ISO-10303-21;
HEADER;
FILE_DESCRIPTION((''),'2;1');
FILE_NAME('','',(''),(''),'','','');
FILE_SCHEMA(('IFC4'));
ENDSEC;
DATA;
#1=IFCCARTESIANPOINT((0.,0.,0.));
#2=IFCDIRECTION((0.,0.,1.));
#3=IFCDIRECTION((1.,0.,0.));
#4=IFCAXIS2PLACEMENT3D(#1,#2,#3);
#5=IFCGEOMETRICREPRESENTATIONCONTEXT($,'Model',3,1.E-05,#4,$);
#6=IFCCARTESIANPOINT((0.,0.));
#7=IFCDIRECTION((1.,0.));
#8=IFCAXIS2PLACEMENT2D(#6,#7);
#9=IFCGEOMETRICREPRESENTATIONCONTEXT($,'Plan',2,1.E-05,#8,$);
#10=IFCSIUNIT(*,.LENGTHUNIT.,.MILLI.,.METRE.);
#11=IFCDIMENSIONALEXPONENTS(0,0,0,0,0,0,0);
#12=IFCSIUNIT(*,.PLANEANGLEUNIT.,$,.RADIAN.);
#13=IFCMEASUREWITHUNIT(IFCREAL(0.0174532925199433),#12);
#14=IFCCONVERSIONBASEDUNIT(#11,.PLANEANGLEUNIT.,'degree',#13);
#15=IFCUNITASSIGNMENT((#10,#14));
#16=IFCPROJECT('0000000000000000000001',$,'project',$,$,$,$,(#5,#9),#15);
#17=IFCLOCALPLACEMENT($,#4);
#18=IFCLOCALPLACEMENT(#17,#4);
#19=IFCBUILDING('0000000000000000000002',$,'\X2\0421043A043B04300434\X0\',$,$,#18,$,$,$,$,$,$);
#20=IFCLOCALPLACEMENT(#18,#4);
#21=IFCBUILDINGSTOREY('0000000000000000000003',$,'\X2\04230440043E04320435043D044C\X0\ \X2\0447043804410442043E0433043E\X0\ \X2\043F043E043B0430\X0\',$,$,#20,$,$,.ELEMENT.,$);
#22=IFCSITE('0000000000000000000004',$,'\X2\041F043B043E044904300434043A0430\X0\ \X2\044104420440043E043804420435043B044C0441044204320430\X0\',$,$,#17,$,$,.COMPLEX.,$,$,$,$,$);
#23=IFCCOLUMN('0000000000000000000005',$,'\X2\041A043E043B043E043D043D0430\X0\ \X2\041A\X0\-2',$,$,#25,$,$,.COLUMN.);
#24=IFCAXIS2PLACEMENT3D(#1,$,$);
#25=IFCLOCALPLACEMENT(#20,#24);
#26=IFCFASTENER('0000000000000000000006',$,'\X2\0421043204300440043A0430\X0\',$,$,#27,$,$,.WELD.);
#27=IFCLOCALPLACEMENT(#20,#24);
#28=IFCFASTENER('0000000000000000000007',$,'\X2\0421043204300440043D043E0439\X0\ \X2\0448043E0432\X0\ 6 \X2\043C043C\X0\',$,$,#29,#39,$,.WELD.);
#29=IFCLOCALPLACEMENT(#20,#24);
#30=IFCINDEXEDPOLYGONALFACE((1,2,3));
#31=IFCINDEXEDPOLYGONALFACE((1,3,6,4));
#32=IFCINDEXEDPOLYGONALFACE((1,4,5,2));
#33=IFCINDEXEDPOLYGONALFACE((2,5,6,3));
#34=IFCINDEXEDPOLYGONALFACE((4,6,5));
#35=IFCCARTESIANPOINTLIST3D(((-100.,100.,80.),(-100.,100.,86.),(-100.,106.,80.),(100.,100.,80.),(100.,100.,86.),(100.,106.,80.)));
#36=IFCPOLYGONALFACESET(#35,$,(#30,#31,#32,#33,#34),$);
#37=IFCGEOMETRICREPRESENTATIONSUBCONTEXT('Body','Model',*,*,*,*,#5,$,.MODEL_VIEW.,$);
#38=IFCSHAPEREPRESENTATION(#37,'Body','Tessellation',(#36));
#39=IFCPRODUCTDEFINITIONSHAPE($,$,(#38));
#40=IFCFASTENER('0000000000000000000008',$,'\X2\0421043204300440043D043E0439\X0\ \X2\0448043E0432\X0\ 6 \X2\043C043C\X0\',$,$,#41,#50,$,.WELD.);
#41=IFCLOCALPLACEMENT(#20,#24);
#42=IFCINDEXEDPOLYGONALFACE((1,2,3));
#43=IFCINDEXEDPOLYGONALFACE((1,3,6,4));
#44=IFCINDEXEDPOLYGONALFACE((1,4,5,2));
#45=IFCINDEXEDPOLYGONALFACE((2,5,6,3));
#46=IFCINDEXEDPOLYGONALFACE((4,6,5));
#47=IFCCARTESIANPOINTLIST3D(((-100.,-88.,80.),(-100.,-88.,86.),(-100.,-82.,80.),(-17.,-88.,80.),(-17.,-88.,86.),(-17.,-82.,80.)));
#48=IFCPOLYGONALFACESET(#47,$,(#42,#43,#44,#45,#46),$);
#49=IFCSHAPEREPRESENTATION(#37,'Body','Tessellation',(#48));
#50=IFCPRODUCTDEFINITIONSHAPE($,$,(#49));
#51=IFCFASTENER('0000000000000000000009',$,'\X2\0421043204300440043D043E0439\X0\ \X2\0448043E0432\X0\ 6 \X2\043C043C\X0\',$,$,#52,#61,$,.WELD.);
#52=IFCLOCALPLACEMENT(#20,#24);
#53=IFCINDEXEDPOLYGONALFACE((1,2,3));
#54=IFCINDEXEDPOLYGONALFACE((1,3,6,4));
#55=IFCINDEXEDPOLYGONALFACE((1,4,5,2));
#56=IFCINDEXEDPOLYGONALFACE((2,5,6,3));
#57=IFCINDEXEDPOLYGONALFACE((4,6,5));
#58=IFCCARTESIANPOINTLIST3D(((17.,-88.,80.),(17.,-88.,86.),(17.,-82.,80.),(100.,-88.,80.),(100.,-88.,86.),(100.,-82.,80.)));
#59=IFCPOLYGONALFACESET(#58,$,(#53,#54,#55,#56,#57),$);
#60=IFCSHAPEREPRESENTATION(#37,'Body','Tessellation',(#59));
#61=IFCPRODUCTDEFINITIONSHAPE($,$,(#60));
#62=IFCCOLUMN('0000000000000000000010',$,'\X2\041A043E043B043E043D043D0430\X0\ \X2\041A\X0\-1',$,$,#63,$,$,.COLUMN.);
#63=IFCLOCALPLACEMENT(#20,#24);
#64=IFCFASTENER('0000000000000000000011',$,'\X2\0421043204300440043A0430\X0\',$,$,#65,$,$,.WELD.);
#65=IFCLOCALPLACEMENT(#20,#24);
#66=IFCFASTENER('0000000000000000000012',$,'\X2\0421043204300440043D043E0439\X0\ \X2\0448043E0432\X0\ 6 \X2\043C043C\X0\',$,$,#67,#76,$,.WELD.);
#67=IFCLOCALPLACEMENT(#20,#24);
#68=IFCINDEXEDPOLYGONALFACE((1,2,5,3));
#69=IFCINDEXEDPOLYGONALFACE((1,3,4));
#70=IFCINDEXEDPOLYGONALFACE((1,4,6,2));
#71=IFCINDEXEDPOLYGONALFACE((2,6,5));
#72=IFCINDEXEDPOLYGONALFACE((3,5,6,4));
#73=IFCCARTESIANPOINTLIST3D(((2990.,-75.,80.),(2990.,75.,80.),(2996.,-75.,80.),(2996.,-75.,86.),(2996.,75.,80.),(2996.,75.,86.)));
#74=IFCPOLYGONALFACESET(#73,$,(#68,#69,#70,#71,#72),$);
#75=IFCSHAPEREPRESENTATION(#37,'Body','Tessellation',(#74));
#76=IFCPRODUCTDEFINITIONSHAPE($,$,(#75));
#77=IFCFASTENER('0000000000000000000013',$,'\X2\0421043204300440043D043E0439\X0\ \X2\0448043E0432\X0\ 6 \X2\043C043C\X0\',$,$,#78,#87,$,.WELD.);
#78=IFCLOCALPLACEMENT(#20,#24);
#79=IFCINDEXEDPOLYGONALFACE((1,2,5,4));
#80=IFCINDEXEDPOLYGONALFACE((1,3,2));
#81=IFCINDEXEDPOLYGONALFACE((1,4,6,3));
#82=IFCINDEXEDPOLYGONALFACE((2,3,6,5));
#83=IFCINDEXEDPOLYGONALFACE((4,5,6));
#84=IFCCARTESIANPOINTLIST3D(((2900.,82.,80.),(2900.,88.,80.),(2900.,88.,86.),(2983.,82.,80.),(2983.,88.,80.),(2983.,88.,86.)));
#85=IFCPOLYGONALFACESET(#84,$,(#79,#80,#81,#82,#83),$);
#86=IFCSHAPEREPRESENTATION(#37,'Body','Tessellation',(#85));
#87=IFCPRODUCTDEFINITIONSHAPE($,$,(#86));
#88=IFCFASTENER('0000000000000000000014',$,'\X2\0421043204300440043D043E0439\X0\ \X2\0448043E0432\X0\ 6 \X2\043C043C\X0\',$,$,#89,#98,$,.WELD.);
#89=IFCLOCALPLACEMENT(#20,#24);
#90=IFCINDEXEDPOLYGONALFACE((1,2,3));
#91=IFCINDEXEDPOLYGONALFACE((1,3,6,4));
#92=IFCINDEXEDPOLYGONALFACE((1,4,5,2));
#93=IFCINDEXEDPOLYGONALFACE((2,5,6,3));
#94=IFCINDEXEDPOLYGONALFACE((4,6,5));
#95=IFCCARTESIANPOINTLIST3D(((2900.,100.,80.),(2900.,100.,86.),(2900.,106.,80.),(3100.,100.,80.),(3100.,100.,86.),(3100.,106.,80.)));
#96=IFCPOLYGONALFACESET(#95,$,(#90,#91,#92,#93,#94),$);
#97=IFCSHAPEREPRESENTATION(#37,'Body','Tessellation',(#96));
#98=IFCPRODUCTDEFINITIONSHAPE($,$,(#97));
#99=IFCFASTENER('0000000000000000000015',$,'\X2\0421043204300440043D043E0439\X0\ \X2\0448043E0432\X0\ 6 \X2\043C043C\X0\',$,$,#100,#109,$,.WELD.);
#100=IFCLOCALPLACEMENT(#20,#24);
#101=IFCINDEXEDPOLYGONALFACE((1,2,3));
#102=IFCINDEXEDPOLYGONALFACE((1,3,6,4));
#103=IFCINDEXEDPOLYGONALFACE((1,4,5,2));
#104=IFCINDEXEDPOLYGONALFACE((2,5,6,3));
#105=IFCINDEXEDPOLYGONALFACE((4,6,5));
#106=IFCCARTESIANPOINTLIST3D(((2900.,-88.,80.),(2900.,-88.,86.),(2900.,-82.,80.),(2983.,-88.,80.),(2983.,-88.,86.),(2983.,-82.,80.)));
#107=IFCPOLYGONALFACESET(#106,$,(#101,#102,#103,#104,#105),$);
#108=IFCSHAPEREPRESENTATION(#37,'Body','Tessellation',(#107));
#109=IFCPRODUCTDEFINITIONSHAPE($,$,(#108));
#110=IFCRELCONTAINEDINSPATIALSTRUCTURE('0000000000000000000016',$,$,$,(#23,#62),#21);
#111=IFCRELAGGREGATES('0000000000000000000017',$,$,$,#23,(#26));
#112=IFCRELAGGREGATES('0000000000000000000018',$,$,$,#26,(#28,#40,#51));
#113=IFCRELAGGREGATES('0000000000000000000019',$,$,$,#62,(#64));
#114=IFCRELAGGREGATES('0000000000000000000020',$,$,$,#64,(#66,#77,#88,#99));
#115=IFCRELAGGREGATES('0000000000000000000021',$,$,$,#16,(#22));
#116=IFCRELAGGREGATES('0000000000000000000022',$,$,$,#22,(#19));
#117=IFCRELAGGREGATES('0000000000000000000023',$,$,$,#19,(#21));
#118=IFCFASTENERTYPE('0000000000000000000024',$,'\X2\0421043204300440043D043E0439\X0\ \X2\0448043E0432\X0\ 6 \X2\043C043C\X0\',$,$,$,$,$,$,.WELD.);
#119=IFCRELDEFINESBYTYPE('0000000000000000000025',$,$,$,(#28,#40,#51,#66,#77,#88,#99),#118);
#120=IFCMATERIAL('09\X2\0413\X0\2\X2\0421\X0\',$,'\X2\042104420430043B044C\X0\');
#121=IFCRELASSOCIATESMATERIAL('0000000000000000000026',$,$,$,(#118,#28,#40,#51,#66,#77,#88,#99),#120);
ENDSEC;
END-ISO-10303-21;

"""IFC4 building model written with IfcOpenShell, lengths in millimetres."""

from ifc_helpers import new_model, entity, si_unit, converted_unit, frame, origin_with_axes, origin_2d_with_axis, place, context, subcontext, project, spatial, line, indexed_curve, outline, extrude, material, material_profile, profile_set, profile_usage, type_object, element, aggregate, save


model = new_model("IFC4")

# Units and contexts
model_context = context("Model", 3, precision=1e-05, world=origin_with_axes())
plan_context = context("Plan", 2, precision=1e-05, world=origin_2d_with_axis())
body_context = subcontext(model_context, "Body", "Model", "MODEL_VIEW")
ifc_project = project(units=[si_unit("LENGTHUNIT", "METRE", prefix="MILLI"), converted_unit("PLANEANGLEUNIT", "degree", entity("IfcReal", 0.0174532925199433), si_unit("PLANEANGLEUNIT", "RADIAN"), dimensions=[0, 0, 0, 0, 0, 0, 0])], contexts=[model_context, plan_context])

# Site, building, storey
site_placement = place(None, origin_with_axes())
site = spatial("IfcSite", under=ifc_project, at=site_placement, Name="Площадка строительства", CompositionType="COMPLEX")
building_placement = place(site_placement, origin_with_axes())
building = spatial("IfcBuilding", under=site, at=building_placement, Name="Склад")
storey_placement = place(building_placement, origin_with_axes())
storey = spatial("IfcBuildingStorey", under=building, at=storey_placement, Name="Уровень чистого пола", CompositionType="ELEMENT")

# Column
placement_1 = place(storey_placement, origin_with_axes())
column_1 = element("IfcColumn", 1, at=placement_1, inside=storey, Name="Колонна К-2", PredefinedType="COLUMN")
placement_2 = place(placement_1, origin_with_axes())

# Shared definitions
ifc_material_1 = material(Name="09Г2С", Category="Сталь")

# Fasteners
fastener_1 = element("IfcFastener", 2, at=placement_2, Name="Сварка", PredefinedType="WELD")
aggregate(column_1, [fastener_1])
ifc_material_profile_1 = material_profile(ifc_material_1, outline(indexed_curve([(0.0, 0.0), (6.0, 0.0), (0.0, 6.0)], segments=[line(2, 3), line(3, 1), line(1, 2)], self_intersect=False)))
ifc_profile_set_1 = profile_set([ifc_material_profile_1])
ifc_profile_usage_1 = profile_usage(ifc_profile_set_1, cardinal=5)
fastener_type = type_object("IfcFastenerType", Name="Сварной шов 6 мм", PredefinedType="WELD", material=ifc_profile_set_1)
fastener_2_placement = place(placement_2, frame((-100.0, 100.0, 80.0), z_axis=(1.0, 0.0, 0.0), x_axis=(0.0, 1.0, 0.0)))
fastener_2 = element("IfcFastener", 3, at=fastener_2_placement, type_object=fastener_type, material=ifc_profile_usage_1, Name="Сварной шов 6 мм", PredefinedType="WELD", context=body_context, shape_type="SweptSolid", body=[
    extrude(outline(indexed_curve([(0.0, 0.0), (6.0, 0.0), (0.0, 6.0)], segments=[line(2, 3), line(3, 1), line(1, 2)], self_intersect=False)), origin_with_axes(), (0.0, 0.0, 1.0), 200.0),
])
fastener_3_placement = place(placement_2, frame((-100.0, -88.0, 80.0), z_axis=(1.0, 0.0, 0.0), x_axis=(0.0, 1.0, 0.0)))
fastener_3 = element("IfcFastener", 4, at=fastener_3_placement, type_object=fastener_type, material=ifc_profile_usage_1, Name="Сварной шов 6 мм", PredefinedType="WELD", context=body_context, shape_type="SweptSolid", body=[
    extrude(outline(indexed_curve([(0.0, 0.0), (6.0, 0.0), (0.0, 6.0)], segments=[line(2, 3), line(3, 1), line(1, 2)], self_intersect=False)), origin_with_axes(), (0.0, 0.0, 1.0), 83.0),
])
fastener_4_placement = place(placement_2, frame((17.0, -88.0, 80.0), z_axis=(1.0, 0.0, 0.0), x_axis=(0.0, 1.0, 0.0)))
fastener_4 = element("IfcFastener", 5, at=fastener_4_placement, type_object=fastener_type, material=ifc_profile_usage_1, Name="Сварной шов 6 мм", PredefinedType="WELD", context=body_context, shape_type="SweptSolid", body=[
    extrude(outline(indexed_curve([(0.0, 0.0), (6.0, 0.0), (0.0, 6.0)], segments=[line(2, 3), line(3, 1), line(1, 2)], self_intersect=False)), origin_with_axes(), (0.0, 0.0, 1.0), 83.0),
])
aggregate(fastener_1, [fastener_2, fastener_3, fastener_4])

# Column, fasteners
column_2 = element("IfcColumn", 6, at=placement_1, inside=storey, Name="Колонна К-1", PredefinedType="COLUMN")
fastener_5_placement = place(placement_1, frame((3000.0, 0.0, 0.0), z_axis=(0.0, 0.0, 1.0), x_axis=(1.0, 0.0, 0.0)))
fastener_5 = element("IfcFastener", 7, at=fastener_5_placement, Name="Сварка", PredefinedType="WELD")
aggregate(column_2, [fastener_5])
fastener_6_placement = place(fastener_5_placement, frame((-4.0, -75.0, 80.0), z_axis=(0.0, 1.0, 0.0), x_axis=(-1.0, 0.0, 0.0)))
fastener_6 = element("IfcFastener", 8, at=fastener_6_placement, type_object=fastener_type, material=ifc_profile_usage_1, Name="Сварной шов 6 мм", PredefinedType="WELD", context=body_context, shape_type="SweptSolid", body=[
    extrude(outline(indexed_curve([(0.0, 0.0), (6.0, 0.0), (0.0, 6.0)], segments=[line(2, 3), line(3, 1), line(1, 2)], self_intersect=False)), origin_with_axes(), (0.0, 0.0, 1.0), 150.0),
])
fastener_7_placement = place(fastener_5_placement, frame((-17.0, 88.0, 80.0), z_axis=(-1.0, 0.0, 0.0), x_axis=(0.0, -1.0, 0.0)))
fastener_7 = element("IfcFastener", 9, at=fastener_7_placement, type_object=fastener_type, material=ifc_profile_usage_1, Name="Сварной шов 6 мм", PredefinedType="WELD", context=body_context, shape_type="SweptSolid", body=[
    extrude(outline(indexed_curve([(0.0, 0.0), (6.0, 0.0), (0.0, 6.0)], segments=[line(2, 3), line(3, 1), line(1, 2)], self_intersect=False)), origin_with_axes(), (0.0, 0.0, 1.0), 83.0),
])
fastener_8_placement = place(fastener_5_placement, frame((-100.0, 100.0, 80.0), z_axis=(1.0, 0.0, 0.0), x_axis=(0.0, 1.0, 0.0)))
fastener_8 = element("IfcFastener", 10, at=fastener_8_placement, type_object=fastener_type, material=ifc_profile_usage_1, Name="Сварной шов 6 мм", PredefinedType="WELD", context=body_context, shape_type="SweptSolid", body=[
    extrude(outline(indexed_curve([(0.0, 0.0), (6.0, 0.0), (0.0, 6.0)], segments=[line(2, 3), line(3, 1), line(1, 2)], self_intersect=False)), origin_with_axes(), (0.0, 0.0, 1.0), 200.0),
])
fastener_9_placement = place(fastener_5_placement, frame((-100.0, -88.0, 80.0), z_axis=(1.0, 0.0, 0.0), x_axis=(0.0, 1.0, 0.0)))
fastener_9 = element("IfcFastener", 11, at=fastener_9_placement, type_object=fastener_type, material=ifc_profile_usage_1, Name="Сварной шов 6 мм", PredefinedType="WELD", context=body_context, shape_type="SweptSolid", body=[
    extrude(outline(indexed_curve([(0.0, 0.0), (6.0, 0.0), (0.0, 6.0)], segments=[line(2, 3), line(3, 1), line(1, 2)], self_intersect=False)), origin_with_axes(), (0.0, 0.0, 1.0), 83.0),
])
aggregate(fastener_5, [fastener_6, fastener_7, fastener_8, fastener_9])

save(model, "model.ifc")
